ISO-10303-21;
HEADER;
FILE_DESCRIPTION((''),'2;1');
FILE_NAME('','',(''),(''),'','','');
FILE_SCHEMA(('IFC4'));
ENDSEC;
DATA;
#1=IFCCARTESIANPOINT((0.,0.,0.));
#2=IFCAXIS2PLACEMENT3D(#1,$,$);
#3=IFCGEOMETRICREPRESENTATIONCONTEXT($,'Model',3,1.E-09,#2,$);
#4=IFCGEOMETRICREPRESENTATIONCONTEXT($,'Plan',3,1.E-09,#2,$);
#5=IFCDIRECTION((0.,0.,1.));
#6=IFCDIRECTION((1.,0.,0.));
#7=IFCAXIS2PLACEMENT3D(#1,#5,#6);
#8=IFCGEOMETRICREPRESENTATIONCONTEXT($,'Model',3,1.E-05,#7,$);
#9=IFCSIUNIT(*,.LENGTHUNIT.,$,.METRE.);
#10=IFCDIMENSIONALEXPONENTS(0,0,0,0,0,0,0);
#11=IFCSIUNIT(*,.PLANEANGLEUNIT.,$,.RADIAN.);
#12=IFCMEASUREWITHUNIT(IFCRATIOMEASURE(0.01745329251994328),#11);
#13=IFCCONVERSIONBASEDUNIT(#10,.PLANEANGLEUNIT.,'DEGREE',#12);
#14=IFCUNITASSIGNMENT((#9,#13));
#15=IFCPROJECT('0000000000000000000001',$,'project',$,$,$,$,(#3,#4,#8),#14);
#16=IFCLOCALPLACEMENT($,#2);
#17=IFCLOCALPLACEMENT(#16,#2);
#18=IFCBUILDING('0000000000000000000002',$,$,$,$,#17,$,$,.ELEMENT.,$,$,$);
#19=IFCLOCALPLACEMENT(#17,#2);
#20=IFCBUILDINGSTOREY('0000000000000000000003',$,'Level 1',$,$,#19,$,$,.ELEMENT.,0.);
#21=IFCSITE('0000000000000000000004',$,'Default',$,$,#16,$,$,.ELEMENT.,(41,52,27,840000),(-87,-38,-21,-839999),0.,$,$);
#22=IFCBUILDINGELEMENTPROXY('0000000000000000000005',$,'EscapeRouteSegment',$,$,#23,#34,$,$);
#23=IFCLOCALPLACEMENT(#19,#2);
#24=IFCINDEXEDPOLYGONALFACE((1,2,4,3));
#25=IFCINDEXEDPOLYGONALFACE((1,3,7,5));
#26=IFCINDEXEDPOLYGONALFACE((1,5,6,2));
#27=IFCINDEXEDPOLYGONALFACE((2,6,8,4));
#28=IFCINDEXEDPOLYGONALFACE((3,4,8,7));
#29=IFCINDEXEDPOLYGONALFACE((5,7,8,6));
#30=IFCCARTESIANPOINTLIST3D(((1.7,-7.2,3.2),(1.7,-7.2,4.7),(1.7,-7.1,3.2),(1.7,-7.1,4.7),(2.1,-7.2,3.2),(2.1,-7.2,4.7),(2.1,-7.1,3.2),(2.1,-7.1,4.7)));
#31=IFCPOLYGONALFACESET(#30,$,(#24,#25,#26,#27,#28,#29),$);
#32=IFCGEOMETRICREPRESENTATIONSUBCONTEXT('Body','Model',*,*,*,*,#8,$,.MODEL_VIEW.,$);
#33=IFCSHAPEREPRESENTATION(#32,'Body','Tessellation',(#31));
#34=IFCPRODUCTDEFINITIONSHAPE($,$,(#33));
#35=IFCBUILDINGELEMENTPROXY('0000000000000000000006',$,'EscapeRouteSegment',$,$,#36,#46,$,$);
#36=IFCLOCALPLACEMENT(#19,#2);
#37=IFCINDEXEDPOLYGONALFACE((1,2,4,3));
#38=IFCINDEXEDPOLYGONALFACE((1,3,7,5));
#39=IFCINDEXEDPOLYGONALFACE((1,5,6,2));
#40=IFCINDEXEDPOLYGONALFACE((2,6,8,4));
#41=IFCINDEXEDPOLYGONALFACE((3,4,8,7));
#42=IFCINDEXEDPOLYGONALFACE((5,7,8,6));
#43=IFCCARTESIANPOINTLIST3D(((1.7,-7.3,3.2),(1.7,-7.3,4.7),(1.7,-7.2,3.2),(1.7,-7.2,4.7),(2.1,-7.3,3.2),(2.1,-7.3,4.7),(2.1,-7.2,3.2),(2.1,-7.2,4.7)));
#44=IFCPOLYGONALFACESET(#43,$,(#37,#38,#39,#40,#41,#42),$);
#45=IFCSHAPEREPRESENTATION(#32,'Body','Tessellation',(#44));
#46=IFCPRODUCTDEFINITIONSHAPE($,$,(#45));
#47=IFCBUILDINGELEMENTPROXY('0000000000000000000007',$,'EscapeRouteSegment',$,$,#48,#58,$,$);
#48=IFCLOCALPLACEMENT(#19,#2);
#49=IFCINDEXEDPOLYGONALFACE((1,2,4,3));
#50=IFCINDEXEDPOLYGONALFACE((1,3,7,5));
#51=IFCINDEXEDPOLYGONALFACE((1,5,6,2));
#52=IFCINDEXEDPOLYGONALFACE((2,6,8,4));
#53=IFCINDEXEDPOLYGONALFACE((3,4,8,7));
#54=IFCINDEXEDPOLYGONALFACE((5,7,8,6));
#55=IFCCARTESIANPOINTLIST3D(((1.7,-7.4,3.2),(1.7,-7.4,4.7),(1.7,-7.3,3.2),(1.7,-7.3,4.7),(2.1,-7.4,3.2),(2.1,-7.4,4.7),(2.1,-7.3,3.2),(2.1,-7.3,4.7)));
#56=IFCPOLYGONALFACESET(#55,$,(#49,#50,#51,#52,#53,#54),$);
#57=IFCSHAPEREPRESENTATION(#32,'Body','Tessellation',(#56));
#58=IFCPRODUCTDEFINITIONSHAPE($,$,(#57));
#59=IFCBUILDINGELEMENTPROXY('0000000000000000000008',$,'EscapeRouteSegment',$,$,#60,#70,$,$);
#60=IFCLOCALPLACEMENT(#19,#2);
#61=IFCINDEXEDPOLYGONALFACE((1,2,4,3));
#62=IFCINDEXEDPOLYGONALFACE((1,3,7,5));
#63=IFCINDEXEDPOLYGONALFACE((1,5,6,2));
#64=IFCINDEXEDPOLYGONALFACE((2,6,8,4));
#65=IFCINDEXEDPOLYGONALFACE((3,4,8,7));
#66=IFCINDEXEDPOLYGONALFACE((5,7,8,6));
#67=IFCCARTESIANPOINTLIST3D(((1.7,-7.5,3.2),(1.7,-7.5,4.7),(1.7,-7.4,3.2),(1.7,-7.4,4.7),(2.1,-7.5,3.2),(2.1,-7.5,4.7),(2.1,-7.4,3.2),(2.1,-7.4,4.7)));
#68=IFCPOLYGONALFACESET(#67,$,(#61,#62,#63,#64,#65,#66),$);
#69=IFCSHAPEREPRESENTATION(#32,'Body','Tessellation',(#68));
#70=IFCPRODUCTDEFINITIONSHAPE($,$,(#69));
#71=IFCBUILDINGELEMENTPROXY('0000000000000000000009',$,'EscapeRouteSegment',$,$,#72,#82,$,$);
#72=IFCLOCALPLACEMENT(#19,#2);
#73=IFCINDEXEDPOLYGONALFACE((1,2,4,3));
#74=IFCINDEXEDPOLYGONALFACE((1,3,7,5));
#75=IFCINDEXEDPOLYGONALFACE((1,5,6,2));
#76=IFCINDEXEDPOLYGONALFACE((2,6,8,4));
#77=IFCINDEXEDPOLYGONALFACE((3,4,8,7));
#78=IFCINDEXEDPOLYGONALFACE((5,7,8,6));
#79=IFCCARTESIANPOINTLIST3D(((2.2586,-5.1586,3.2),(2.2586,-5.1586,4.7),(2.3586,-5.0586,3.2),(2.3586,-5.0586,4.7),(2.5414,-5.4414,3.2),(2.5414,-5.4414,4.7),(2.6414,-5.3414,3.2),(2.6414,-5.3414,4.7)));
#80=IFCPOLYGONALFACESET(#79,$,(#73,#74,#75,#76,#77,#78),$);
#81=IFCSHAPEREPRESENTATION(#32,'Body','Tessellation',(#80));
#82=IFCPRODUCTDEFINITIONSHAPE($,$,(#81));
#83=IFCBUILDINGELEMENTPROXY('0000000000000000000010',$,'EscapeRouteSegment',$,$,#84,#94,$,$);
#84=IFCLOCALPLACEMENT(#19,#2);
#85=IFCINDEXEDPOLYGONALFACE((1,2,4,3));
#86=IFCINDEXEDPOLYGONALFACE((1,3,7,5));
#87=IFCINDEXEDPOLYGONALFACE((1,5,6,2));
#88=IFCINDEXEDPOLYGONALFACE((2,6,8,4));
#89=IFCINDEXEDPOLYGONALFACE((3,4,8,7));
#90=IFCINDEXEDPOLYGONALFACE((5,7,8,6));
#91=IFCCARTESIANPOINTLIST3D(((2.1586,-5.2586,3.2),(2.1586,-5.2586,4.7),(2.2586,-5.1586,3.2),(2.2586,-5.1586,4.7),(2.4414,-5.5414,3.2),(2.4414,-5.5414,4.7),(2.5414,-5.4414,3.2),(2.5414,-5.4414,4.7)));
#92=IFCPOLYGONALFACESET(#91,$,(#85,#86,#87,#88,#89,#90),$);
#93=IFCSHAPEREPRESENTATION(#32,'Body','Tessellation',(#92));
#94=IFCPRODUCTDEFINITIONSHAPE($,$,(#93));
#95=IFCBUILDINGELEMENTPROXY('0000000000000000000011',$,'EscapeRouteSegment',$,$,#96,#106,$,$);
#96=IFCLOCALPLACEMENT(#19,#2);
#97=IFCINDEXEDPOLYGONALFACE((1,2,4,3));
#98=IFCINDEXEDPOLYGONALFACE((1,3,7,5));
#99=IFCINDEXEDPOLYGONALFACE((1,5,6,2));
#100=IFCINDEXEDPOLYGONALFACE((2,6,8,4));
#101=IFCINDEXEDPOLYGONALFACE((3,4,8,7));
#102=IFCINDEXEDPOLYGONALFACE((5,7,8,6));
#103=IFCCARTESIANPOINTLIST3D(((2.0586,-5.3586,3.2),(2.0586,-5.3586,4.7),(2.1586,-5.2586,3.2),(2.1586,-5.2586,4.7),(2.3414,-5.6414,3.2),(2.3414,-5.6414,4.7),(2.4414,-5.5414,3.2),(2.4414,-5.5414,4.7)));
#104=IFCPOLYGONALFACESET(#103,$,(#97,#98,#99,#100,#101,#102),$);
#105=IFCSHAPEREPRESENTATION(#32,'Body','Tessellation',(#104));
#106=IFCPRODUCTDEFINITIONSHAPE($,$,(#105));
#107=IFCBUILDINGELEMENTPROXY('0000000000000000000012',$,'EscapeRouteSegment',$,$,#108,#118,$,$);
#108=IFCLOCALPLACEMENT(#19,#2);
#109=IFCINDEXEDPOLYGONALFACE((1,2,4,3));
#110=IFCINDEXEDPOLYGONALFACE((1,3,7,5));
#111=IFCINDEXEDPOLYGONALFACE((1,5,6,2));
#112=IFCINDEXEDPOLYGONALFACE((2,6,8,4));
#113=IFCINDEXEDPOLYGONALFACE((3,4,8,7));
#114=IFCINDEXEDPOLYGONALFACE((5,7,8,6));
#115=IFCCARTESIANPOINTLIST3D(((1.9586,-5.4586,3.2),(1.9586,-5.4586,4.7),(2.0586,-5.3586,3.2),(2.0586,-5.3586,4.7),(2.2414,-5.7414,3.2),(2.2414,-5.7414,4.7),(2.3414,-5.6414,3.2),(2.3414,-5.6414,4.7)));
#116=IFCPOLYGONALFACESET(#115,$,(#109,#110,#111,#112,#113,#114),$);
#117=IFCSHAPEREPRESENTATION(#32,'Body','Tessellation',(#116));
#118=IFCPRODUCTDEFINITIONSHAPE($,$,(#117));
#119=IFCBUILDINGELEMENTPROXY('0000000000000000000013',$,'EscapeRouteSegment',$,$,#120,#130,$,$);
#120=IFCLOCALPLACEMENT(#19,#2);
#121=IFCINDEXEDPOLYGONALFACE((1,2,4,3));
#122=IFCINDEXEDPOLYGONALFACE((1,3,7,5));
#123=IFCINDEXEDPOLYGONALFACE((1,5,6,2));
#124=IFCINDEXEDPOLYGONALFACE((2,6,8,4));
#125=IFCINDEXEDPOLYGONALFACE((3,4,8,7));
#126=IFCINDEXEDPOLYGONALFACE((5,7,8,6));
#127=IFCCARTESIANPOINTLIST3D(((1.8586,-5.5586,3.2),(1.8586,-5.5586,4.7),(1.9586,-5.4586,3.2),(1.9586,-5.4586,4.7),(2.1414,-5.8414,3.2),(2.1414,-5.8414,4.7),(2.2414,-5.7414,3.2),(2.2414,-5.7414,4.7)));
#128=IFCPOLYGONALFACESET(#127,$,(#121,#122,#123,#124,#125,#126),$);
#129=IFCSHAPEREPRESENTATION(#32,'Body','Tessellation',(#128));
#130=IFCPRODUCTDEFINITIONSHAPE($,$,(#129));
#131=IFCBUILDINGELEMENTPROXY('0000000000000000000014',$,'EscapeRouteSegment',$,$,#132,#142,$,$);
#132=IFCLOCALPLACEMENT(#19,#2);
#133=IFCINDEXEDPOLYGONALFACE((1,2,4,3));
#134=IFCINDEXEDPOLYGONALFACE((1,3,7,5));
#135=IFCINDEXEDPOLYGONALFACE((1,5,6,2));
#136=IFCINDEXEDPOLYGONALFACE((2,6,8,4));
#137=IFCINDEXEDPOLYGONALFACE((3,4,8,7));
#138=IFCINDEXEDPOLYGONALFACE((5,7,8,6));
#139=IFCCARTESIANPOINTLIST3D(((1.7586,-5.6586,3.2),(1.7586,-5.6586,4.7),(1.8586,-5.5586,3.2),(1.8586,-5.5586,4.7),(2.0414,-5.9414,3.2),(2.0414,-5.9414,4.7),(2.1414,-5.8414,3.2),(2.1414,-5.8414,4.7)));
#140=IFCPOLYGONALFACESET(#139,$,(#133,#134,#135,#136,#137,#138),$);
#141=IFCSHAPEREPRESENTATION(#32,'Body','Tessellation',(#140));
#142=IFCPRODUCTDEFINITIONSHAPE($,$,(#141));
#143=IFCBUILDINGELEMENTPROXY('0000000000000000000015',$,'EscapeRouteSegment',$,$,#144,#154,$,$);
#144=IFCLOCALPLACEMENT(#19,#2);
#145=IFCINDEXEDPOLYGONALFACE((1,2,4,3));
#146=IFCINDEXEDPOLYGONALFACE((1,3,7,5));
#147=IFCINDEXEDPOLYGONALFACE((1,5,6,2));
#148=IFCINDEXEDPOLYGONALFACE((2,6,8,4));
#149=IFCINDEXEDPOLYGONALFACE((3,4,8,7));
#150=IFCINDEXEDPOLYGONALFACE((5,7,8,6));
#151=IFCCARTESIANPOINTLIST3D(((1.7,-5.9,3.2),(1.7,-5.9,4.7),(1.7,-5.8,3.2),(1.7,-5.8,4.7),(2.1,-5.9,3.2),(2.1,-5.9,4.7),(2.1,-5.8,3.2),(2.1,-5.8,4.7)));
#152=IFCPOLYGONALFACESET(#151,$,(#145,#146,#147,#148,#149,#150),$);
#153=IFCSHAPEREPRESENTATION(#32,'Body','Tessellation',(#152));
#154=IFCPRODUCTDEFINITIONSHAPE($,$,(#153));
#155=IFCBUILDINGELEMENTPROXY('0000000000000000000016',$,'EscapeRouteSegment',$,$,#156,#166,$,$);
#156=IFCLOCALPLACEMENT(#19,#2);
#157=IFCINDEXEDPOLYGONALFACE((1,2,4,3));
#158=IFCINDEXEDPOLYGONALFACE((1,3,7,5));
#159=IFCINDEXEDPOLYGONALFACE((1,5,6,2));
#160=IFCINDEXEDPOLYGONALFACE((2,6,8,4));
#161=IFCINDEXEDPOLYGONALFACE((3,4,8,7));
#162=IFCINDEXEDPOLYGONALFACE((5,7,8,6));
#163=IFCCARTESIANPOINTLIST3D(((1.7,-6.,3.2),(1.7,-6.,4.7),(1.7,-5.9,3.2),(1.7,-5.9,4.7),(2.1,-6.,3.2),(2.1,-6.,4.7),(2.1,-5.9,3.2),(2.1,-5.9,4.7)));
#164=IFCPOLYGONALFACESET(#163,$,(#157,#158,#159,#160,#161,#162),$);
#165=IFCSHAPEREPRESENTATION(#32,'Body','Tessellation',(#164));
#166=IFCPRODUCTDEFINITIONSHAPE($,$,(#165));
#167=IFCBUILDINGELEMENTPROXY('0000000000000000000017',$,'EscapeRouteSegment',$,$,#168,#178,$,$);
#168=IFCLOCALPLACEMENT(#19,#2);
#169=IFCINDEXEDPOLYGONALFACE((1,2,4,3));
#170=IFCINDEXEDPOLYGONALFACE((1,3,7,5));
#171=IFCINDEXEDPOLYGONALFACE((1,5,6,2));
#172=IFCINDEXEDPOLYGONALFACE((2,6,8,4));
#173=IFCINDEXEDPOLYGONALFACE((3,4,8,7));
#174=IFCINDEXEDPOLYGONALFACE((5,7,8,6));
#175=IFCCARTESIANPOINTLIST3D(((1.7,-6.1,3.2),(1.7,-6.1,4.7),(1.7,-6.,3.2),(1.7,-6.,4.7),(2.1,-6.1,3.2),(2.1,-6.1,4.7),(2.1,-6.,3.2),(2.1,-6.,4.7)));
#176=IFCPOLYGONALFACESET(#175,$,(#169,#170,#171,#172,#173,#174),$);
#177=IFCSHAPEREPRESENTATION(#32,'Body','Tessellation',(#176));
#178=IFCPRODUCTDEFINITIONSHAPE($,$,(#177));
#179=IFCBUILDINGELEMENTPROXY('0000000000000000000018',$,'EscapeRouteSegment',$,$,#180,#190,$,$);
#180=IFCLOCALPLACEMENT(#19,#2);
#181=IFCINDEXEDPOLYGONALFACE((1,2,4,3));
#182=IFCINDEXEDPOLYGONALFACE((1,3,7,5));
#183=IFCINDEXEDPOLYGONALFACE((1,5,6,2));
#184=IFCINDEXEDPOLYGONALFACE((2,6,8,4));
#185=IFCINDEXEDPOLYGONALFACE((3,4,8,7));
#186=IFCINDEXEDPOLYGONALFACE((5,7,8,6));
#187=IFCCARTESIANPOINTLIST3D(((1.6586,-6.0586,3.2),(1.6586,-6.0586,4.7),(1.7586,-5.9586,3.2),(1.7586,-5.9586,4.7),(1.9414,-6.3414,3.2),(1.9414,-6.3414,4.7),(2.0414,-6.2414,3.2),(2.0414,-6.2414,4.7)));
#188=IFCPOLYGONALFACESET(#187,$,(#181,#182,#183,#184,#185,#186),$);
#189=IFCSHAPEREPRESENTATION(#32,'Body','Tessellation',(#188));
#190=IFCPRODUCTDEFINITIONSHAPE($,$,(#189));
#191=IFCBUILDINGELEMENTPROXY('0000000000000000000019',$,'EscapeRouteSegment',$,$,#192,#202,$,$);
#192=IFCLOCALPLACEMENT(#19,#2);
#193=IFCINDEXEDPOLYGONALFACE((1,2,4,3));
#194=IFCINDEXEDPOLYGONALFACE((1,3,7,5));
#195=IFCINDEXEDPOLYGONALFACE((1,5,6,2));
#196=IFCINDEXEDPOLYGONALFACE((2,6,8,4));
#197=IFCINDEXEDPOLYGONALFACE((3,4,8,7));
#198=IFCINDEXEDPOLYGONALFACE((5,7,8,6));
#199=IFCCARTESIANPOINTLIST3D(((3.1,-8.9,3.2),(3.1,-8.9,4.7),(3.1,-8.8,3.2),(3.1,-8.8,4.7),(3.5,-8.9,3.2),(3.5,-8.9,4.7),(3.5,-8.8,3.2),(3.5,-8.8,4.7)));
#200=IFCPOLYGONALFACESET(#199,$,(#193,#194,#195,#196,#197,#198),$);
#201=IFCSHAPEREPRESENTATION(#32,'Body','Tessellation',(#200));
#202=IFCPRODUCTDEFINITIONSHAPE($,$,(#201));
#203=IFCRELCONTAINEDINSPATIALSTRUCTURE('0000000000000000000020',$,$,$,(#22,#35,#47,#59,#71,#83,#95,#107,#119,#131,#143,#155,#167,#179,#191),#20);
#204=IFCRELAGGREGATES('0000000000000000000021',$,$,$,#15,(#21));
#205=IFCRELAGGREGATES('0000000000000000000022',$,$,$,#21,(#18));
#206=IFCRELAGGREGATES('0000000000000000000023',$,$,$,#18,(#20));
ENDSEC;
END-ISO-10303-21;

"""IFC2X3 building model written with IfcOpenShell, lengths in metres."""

from ifc_helpers import new_model, entity, si_unit, converted_unit, frame, origin, origin_with_axes, place, context, subcontext, project, spatial, polyline, outline, extrude, element, save


model = new_model("IFC2X3")

# Units and contexts
model_context_1 = context("Model", 3, precision=1e-09, world=origin())
plan_context = context("Plan", 3, precision=1e-09, world=origin())
model_context_2 = context("Model", 3, precision=1e-05, world=origin_with_axes())
body_context = subcontext(model_context_2, "Body", "Model", "MODEL_VIEW")
ifc_project = project(units=[si_unit("LENGTHUNIT", "METRE"), converted_unit("PLANEANGLEUNIT", "DEGREE", entity("IfcRatioMeasure", 0.01745329251994328), si_unit("PLANEANGLEUNIT", "RADIAN"), dimensions=[0, 0, 0, 0, 0, 0, 0])], contexts=[model_context_1, plan_context, model_context_2])

# Site, building, storey
site_placement = place(None, origin())
site = spatial("IfcSite", under=ifc_project, at=site_placement, Name="Default", CompositionType="ELEMENT", RefLatitude=(41, 52, 27, 840000), RefLongitude=(-87, -38, -21, -839999), RefElevation=0.0)
building_placement = place(site_placement, origin())
building = spatial("IfcBuilding", under=site, at=building_placement, CompositionType="ELEMENT")
storey_placement = place(building_placement, origin())
storey = spatial("IfcBuildingStorey", under=building, at=storey_placement, Name="Level 1", CompositionType="ELEMENT", Elevation=0.0)

# Building element proxies
for number, where, z_axis, x_axis, name in (
    (1, (1.9, -7.1, 3.2), (0.0, 0.0, 1.0), (0.0, -1.0, 0.0), "EscapeRouteSegment"),
):
    element("IfcBuildingElementProxy", number, at=place(storey_placement, frame(where, z_axis=z_axis, x_axis=x_axis)), inside=storey, Name=name, context=body_context, shape_type="SweptSolid", body=[
        extrude(outline(polyline([(0.0, -0.2), (0.0, 0.2), (0.1, 0.2), (0.1, -0.2), (0.0, -0.2)])), origin_with_axes(), (0.0, 0.0, 1.0), 1.5),
    ])
proxy_1_placement = place(storey_placement, frame((1.9, -7.2, 3.2), z_axis=(0.0, 0.0, 1.0), x_axis=(0.0, -1.0, 0.0)))
element("IfcBuildingElementProxy", 2, at=proxy_1_placement, inside=storey, Name="EscapeRouteSegment", context=body_context, shape_type="SweptSolid", body=[
    extrude(outline(polyline([(0.0, -0.2), (0.0, 0.2), (0.1, 0.2), (0.1, -0.2), (0.0, -0.2)])), origin_with_axes(), (0.0, 0.0, 1.0), 1.5),
])
for number, where, z_axis, x_axis, name in (
    (3, (1.9, -7.3, 3.2), (0.0, 0.0, 1.0), (0.0, -1.0, 0.0), "EscapeRouteSegment"),
    (4, (1.9, -7.4, 3.2), (0.0, 0.0, 1.0), (0.0, -1.0, 0.0), "EscapeRouteSegment"),
):
    element("IfcBuildingElementProxy", number, at=place(storey_placement, frame(where, z_axis=z_axis, x_axis=x_axis)), inside=storey, Name=name, context=body_context, shape_type="SweptSolid", body=[
        extrude(outline(polyline([(0.0, -0.2), (0.0, 0.2), (0.1, 0.2), (0.1, -0.2), (0.0, -0.2)])), origin_with_axes(), (0.0, 0.0, 1.0), 1.5),
    ])
proxy_2_placement = place(storey_placement, frame((2.5, -5.2, 3.2), z_axis=(0.0, 0.0, 1.0), x_axis=(-0.707105, -0.707108, 0.0)))
element("IfcBuildingElementProxy", 5, at=proxy_2_placement, inside=storey, Name="EscapeRouteSegment", context=body_context, shape_type="SweptSolid", body=[
    extrude(outline(polyline([(0.0, -0.2), (0.0, 0.2), (0.1414, 0.2), (0.1414, -0.2), (0.0, -0.2)])), origin_with_axes(), (0.0, 0.0, 1.0), 1.5),
])
proxy_3_placement = place(storey_placement, frame((2.4, -5.3, 3.2), z_axis=(0.0, 0.0, 1.0), x_axis=(-0.707108, -0.707106, 0.0)))
element("IfcBuildingElementProxy", 6, at=proxy_3_placement, inside=storey, Name="EscapeRouteSegment", context=body_context, shape_type="SweptSolid", body=[
    extrude(outline(polyline([(0.0, -0.2), (0.0, 0.2), (0.1414, 0.2), (0.1414, -0.2), (0.0, -0.2)])), origin_with_axes(), (0.0, 0.0, 1.0), 1.5),
])
proxy_4_placement = place(storey_placement, frame((2.3, -5.4, 3.2), z_axis=(0.0, 0.0, 1.0), x_axis=(-0.707107, -0.707107, 0.0)))
element("IfcBuildingElementProxy", 7, at=proxy_4_placement, inside=storey, Name="EscapeRouteSegment", context=body_context, shape_type="SweptSolid", body=[
    extrude(outline(polyline([(0.0, -0.2), (0.0, 0.2), (0.1414, 0.2), (0.1414, -0.2), (0.0, -0.2)])), origin_with_axes(), (0.0, 0.0, 1.0), 1.5),
])
proxy_5_placement = place(storey_placement, frame((2.2, -5.5, 3.2), z_axis=(0.0, 0.0, 1.0), x_axis=(-0.707108, -0.707106, 0.0)))
element("IfcBuildingElementProxy", 8, at=proxy_5_placement, inside=storey, Name="EscapeRouteSegment", context=body_context, shape_type="SweptSolid", body=[
    extrude(outline(polyline([(0.0, -0.2), (0.0, 0.2), (0.1414, 0.2), (0.1414, -0.2), (0.0, -0.2)])), origin_with_axes(), (0.0, 0.0, 1.0), 1.5),
])
proxy_6_placement = place(storey_placement, frame((2.1, -5.6, 3.2), z_axis=(0.0, 0.0, 1.0), x_axis=(-0.707107, -0.707107, 0.0)))
element("IfcBuildingElementProxy", 9, at=proxy_6_placement, inside=storey, Name="EscapeRouteSegment", context=body_context, shape_type="SweptSolid", body=[
    extrude(outline(polyline([(0.0, -0.2), (0.0, 0.2), (0.1414, 0.2), (0.1414, -0.2), (0.0, -0.2)])), origin_with_axes(), (0.0, 0.0, 1.0), 1.5),
])
proxy_7_placement = place(storey_placement, frame((2.0, -5.7, 3.2), z_axis=(0.0, 0.0, 1.0), x_axis=(-0.707105, -0.707108, 0.0)))
element("IfcBuildingElementProxy", 10, at=proxy_7_placement, inside=storey, Name="EscapeRouteSegment", context=body_context, shape_type="SweptSolid", body=[
    extrude(outline(polyline([(0.0, -0.2), (0.0, 0.2), (0.1414, 0.2), (0.1414, -0.2), (0.0, -0.2)])), origin_with_axes(), (0.0, 0.0, 1.0), 1.5),
])
for number, where, z_axis, x_axis, name in (
    (11, (1.9, -5.8, 3.2), (0.0, 0.0, 1.0), (0.0, -1.0, 0.0), "EscapeRouteSegment"),
    (12, (1.9, -5.9, 3.2), (0.0, 0.0, 1.0), (0.0, -1.0, 0.0), "EscapeRouteSegment"),
    (13, (1.9, -6.0, 3.2), (0.0, 0.0, 1.0), (0.0, -1.0, 0.0), "EscapeRouteSegment"),
):
    element("IfcBuildingElementProxy", number, at=place(storey_placement, frame(where, z_axis=z_axis, x_axis=x_axis)), inside=storey, Name=name, context=body_context, shape_type="SweptSolid", body=[
        extrude(outline(polyline([(0.0, -0.2), (0.0, 0.2), (0.1, 0.2), (0.1, -0.2), (0.0, -0.2)])), origin_with_axes(), (0.0, 0.0, 1.0), 1.5),
    ])
proxy_8_placement = place(storey_placement, frame((1.9, -6.1, 3.2), z_axis=(0.0, 0.0, 1.0), x_axis=(-0.707107, -0.707106, 0.0)))
element("IfcBuildingElementProxy", 14, at=proxy_8_placement, inside=storey, Name="EscapeRouteSegment", context=body_context, shape_type="SweptSolid", body=[
    extrude(outline(polyline([(0.0, -0.2), (0.0, 0.2), (0.1414, 0.2), (0.1414, -0.2), (0.0, -0.2)])), origin_with_axes(), (0.0, 0.0, 1.0), 1.5),
])
proxy_9_placement = place(storey_placement, frame((3.3, -8.8, 3.2), z_axis=(0.0, 0.0, 1.0), x_axis=(0.0, -1.0, 0.0)))
element("IfcBuildingElementProxy", 15, at=proxy_9_placement, inside=storey, Name="EscapeRouteSegment", context=body_context, shape_type="SweptSolid", body=[
    extrude(outline(polyline([(0.0, -0.2), (0.0, 0.2), (0.1, 0.2), (0.1, -0.2), (0.0, -0.2)])), origin_with_axes(), (0.0, 0.0, 1.0), 1.5),
])

save(model, "model.ifc")
